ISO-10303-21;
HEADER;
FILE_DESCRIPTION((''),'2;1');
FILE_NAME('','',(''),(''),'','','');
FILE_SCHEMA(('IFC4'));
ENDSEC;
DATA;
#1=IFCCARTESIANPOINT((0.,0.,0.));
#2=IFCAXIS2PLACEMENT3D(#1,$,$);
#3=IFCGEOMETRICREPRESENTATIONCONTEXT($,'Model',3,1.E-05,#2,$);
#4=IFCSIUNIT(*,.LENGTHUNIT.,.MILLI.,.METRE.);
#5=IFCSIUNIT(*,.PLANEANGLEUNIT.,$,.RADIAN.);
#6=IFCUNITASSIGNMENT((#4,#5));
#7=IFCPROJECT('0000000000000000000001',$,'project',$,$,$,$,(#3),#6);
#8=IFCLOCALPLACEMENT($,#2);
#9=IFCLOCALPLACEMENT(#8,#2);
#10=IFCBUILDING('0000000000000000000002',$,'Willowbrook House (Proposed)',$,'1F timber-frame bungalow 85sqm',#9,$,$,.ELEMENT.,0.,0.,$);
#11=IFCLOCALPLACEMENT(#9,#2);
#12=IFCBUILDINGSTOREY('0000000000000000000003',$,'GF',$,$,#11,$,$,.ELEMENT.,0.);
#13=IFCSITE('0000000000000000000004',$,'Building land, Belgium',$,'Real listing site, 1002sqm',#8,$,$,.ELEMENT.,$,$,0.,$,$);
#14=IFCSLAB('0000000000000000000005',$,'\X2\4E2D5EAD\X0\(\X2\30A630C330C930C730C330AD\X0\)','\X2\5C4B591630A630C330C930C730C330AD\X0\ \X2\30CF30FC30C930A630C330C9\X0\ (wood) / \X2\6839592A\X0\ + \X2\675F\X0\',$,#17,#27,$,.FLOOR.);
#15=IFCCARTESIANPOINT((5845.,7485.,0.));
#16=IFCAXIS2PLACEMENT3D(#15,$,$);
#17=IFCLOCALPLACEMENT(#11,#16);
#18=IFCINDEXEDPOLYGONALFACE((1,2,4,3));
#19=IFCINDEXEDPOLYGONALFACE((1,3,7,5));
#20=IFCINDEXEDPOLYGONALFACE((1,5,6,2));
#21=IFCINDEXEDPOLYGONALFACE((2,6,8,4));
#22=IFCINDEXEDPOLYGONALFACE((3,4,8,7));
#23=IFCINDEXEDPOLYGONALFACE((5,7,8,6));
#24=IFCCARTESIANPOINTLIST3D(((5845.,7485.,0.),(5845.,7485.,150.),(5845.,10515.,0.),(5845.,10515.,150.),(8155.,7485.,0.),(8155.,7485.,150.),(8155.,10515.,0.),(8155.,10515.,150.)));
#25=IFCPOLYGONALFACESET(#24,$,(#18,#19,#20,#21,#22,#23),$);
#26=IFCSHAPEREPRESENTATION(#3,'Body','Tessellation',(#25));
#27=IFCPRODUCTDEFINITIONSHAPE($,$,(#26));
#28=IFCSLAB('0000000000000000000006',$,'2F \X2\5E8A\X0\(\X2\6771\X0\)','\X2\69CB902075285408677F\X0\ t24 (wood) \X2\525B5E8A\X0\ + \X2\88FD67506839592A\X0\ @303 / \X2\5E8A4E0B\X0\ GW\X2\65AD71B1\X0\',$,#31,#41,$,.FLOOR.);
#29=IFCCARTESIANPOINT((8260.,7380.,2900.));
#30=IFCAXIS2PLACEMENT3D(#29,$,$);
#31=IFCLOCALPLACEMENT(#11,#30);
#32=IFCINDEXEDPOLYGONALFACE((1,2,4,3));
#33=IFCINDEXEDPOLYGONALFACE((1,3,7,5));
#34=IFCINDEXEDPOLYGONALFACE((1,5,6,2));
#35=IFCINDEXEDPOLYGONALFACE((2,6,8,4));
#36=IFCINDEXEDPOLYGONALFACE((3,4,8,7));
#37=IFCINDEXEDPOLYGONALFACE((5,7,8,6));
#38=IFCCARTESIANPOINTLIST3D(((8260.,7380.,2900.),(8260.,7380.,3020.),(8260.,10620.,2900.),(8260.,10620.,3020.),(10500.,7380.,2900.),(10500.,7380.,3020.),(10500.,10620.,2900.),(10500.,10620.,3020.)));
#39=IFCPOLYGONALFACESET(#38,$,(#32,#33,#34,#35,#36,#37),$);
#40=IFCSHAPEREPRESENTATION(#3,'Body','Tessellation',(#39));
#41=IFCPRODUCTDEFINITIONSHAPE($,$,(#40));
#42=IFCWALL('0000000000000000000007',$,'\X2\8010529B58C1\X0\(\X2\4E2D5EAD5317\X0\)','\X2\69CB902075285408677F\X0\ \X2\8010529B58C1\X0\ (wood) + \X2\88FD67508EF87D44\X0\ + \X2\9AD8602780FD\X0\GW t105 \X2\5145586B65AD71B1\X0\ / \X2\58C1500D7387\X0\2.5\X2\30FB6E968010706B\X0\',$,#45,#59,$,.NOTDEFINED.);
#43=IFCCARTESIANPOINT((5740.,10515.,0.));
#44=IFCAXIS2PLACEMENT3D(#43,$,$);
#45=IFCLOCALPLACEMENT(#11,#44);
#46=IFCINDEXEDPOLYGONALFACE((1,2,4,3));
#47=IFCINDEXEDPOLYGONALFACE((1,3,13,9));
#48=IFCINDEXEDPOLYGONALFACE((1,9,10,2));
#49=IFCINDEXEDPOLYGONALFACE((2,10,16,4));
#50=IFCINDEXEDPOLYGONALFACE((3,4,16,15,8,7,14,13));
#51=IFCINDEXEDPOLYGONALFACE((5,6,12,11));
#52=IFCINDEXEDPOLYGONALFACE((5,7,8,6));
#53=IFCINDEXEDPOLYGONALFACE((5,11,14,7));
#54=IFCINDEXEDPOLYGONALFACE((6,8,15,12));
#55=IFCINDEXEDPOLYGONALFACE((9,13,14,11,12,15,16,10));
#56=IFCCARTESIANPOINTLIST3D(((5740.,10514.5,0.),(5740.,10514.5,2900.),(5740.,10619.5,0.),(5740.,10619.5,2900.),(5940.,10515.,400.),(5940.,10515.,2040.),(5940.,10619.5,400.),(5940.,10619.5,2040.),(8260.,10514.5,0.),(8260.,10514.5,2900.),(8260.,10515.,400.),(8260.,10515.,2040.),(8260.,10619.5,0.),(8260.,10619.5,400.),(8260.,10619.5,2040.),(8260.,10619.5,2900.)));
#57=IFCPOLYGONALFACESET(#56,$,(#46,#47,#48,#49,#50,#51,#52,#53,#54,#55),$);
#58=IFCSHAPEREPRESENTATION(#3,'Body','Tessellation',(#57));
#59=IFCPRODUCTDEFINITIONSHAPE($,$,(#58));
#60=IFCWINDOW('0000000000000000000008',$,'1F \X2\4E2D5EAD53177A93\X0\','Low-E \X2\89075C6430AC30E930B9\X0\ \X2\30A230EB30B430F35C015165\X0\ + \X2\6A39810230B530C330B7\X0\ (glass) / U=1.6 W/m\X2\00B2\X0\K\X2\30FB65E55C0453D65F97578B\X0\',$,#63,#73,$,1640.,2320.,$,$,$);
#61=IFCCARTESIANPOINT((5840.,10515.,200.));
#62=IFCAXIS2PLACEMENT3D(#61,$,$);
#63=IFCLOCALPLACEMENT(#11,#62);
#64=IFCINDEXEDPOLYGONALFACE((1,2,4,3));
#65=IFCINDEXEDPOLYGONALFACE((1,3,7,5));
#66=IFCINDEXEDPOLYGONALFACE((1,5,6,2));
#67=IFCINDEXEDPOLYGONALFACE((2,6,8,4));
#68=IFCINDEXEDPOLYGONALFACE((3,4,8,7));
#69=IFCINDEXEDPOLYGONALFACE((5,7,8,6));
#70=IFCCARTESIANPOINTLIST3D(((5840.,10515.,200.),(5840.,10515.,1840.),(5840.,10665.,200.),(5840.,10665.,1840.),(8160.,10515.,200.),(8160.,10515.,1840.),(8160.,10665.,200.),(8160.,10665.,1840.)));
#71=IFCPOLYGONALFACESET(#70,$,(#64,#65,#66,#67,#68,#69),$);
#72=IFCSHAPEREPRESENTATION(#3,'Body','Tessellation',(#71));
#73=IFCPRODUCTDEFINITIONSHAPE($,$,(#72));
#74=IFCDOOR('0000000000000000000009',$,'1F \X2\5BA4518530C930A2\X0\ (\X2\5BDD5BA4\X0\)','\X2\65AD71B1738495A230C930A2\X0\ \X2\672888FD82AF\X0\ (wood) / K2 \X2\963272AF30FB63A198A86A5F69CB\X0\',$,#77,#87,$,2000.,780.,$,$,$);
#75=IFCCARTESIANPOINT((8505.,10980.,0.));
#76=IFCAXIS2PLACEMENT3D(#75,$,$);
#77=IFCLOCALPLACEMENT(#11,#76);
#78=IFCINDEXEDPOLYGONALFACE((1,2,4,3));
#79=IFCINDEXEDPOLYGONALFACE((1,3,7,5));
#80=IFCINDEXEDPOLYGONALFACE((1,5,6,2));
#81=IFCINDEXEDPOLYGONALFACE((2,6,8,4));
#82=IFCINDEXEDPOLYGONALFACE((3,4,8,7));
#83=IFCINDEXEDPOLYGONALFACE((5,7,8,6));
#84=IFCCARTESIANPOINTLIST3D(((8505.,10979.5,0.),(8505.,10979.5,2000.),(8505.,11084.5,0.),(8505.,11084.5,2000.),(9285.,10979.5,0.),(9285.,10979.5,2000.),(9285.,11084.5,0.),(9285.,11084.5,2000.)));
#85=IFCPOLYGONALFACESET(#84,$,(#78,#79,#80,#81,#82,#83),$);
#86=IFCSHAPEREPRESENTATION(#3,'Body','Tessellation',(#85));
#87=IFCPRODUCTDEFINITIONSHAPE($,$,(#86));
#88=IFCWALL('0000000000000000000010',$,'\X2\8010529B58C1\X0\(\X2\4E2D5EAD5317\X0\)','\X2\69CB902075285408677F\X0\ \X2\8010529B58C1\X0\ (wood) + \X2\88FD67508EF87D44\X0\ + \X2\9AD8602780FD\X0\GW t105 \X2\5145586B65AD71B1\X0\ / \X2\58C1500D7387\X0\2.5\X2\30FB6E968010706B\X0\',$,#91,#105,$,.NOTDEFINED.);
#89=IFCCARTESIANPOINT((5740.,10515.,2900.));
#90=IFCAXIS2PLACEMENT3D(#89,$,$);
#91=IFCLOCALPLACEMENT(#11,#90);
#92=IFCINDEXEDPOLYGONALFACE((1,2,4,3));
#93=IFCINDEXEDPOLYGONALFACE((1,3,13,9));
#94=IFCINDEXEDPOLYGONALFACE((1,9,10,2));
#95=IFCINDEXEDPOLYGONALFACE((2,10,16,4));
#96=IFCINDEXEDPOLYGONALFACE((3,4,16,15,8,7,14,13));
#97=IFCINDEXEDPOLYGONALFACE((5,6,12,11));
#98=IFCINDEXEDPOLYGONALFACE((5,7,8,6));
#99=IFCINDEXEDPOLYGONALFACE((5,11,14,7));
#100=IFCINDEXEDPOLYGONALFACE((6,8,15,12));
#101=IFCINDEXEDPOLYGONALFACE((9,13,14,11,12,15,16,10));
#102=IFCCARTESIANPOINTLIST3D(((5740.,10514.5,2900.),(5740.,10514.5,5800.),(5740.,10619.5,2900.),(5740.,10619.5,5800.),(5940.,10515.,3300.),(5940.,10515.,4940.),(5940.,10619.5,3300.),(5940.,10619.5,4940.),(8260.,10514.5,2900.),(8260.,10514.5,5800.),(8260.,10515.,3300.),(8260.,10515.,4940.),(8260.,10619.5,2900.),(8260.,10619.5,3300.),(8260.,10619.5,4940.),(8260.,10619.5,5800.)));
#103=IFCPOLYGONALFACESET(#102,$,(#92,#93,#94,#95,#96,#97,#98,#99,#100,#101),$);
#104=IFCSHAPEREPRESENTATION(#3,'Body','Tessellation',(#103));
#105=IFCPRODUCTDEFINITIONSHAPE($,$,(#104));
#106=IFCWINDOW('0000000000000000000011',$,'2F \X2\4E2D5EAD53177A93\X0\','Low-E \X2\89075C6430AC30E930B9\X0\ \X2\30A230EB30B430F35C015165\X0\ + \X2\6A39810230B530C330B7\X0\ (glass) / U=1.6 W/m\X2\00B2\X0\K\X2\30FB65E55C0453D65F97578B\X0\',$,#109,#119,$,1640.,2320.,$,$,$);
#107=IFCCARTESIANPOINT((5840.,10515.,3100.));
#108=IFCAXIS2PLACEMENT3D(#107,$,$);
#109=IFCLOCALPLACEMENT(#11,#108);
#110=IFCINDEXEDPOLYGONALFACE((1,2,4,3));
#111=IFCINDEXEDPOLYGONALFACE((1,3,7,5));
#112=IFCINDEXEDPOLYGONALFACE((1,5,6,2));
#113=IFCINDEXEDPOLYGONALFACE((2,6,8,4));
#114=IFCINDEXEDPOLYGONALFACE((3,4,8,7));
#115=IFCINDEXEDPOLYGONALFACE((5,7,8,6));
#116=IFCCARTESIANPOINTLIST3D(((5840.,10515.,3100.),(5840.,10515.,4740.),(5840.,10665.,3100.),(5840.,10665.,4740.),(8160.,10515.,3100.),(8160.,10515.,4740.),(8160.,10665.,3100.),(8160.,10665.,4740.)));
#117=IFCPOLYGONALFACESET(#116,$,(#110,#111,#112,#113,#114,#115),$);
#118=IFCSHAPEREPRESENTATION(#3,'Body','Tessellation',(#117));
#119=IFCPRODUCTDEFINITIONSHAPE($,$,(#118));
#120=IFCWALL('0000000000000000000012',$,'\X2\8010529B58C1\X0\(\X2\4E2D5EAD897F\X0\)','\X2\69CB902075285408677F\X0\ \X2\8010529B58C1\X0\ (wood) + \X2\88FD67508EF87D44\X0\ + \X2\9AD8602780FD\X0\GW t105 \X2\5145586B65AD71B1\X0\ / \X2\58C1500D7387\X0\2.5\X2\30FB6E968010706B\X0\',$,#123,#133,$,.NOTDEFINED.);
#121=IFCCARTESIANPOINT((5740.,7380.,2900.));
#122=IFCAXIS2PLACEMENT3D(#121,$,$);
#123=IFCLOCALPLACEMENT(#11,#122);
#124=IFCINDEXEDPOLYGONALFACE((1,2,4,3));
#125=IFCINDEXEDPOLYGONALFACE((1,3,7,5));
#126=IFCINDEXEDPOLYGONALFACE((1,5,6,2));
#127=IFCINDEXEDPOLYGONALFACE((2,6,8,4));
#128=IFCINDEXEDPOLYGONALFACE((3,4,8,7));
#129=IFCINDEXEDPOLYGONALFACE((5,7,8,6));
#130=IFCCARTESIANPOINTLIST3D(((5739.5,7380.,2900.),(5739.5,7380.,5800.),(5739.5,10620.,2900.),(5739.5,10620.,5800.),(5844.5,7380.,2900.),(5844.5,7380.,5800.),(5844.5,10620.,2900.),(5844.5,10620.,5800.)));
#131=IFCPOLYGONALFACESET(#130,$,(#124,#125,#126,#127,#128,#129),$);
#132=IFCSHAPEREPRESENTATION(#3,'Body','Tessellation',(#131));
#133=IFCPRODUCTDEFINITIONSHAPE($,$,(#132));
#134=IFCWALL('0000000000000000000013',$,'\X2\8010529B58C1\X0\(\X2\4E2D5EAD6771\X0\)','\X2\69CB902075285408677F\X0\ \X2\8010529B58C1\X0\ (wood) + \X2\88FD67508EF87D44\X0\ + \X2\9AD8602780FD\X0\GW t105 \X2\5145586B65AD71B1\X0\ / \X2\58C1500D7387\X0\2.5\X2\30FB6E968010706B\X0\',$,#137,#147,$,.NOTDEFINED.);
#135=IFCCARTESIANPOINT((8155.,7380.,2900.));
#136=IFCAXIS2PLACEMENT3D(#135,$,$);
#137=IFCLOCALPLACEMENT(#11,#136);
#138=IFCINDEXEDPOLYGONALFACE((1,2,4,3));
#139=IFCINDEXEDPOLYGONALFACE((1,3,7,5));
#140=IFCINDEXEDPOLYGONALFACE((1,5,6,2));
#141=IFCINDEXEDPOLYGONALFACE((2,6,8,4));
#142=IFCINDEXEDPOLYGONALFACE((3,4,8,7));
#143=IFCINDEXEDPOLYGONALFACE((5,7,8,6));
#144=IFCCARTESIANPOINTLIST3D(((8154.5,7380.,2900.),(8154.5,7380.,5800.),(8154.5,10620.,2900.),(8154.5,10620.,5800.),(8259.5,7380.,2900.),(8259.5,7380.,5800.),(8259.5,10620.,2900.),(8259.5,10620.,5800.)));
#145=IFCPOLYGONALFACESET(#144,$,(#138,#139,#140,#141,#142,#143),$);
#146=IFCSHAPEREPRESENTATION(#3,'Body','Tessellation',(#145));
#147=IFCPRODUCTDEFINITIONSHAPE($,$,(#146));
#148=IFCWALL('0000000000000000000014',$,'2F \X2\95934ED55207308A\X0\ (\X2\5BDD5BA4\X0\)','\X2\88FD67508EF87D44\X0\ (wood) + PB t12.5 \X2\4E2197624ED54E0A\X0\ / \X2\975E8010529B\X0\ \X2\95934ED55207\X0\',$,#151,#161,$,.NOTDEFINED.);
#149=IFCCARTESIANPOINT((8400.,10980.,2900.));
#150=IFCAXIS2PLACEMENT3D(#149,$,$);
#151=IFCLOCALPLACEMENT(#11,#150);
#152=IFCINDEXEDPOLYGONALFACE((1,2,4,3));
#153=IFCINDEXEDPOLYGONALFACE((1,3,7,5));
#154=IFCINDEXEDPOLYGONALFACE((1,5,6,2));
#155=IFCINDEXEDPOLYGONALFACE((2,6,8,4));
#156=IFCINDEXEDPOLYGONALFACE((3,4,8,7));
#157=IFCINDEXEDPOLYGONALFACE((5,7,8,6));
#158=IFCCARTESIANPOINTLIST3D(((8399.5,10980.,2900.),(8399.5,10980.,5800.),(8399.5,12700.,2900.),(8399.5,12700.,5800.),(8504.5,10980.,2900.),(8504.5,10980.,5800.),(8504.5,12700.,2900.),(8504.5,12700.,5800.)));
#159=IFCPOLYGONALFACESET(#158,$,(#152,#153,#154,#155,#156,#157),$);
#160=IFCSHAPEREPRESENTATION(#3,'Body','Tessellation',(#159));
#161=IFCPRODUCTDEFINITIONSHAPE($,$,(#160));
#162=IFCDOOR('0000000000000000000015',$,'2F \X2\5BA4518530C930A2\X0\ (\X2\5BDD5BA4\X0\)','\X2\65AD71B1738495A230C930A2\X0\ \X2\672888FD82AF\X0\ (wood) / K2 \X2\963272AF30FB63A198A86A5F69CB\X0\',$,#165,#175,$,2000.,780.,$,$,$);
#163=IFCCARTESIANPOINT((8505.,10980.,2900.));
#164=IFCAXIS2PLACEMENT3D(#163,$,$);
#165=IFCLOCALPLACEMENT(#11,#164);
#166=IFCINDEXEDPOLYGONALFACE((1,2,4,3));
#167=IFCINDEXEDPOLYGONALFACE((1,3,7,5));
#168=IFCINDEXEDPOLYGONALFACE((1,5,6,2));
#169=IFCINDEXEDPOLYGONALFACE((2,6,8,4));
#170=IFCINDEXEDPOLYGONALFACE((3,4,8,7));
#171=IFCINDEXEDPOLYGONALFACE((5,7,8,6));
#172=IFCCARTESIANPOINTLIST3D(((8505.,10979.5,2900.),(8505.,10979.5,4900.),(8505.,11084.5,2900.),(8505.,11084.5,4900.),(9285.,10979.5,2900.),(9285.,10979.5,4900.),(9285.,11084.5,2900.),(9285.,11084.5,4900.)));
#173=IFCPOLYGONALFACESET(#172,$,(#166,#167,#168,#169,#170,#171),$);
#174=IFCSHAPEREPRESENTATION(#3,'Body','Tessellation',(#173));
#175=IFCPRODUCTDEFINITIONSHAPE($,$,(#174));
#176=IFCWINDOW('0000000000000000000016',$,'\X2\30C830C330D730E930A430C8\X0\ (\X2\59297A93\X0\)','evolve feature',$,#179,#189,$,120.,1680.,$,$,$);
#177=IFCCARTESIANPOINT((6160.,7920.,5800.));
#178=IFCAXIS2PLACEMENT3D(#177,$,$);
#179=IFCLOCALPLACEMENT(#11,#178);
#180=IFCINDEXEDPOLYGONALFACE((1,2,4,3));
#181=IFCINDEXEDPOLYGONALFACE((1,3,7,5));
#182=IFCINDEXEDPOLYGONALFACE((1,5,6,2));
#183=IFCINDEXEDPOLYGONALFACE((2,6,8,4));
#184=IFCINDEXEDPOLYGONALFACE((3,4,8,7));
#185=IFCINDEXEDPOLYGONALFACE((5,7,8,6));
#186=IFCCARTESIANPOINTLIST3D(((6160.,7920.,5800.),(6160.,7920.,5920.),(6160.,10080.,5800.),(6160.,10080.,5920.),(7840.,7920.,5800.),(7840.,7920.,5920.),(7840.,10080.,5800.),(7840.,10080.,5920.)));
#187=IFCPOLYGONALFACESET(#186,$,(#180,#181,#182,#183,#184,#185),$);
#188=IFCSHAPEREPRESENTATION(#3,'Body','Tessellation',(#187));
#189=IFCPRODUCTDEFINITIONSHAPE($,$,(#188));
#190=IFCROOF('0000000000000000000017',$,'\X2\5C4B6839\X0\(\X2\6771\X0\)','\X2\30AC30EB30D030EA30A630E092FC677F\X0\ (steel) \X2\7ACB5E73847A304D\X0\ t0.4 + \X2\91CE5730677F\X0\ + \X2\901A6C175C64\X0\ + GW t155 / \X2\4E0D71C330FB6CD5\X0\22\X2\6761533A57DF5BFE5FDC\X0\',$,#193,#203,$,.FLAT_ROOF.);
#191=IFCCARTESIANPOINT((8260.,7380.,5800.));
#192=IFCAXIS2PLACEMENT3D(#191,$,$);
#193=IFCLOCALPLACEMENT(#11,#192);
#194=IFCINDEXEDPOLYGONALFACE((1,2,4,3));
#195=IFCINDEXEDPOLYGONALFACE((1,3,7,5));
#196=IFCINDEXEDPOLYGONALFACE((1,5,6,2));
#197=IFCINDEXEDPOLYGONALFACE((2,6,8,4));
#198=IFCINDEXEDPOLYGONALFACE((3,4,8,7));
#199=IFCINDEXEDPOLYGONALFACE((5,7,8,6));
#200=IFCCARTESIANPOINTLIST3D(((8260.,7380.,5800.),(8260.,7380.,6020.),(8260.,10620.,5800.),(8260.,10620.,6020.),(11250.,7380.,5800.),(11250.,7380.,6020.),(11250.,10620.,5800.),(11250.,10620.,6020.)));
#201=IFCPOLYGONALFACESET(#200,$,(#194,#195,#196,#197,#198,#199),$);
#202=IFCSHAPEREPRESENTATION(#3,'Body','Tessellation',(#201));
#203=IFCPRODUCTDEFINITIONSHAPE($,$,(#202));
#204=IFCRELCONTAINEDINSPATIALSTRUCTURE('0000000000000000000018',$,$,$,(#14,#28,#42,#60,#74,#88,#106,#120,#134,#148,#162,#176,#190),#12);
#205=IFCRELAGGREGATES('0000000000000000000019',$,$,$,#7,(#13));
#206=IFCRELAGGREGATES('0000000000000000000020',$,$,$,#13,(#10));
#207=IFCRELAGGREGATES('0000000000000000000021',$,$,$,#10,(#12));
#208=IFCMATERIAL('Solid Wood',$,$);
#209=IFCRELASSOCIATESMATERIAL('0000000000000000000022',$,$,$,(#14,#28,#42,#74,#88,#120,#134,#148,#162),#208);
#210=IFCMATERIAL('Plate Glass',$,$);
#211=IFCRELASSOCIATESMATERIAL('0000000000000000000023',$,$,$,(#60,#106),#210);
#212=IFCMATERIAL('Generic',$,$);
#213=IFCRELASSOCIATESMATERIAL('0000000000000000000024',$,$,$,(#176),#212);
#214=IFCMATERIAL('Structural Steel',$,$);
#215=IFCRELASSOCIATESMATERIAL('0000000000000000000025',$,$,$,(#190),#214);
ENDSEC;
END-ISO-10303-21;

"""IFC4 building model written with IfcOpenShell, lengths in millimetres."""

from ifc_helpers import new_model, si_unit, frame, frame_2d, origin, place, context, project, spatial, rectangle, extrude, material, element, fill, save


model = new_model("IFC4")

# Units and contexts
model_context = context("Model", 3, precision=1e-05, world=origin())
ifc_project = project(units=[si_unit("LENGTHUNIT", "METRE", prefix="MILLI"), si_unit("PLANEANGLEUNIT", "RADIAN")], contexts=[model_context])

# Site, building, storey
site_placement = place(None, origin())
site = spatial("IfcSite", under=ifc_project, at=site_placement, Name="Building land, Belgium", ObjectType="Real listing site, 1002sqm", CompositionType="ELEMENT", RefElevation=0.0)
building_placement = place(site_placement, origin())
building = spatial("IfcBuilding", under=site, at=building_placement, Name="Willowbrook House (Proposed)", ObjectType="1F timber-frame bungalow 85sqm", CompositionType="ELEMENT", ElevationOfRefHeight=0.0, ElevationOfTerrain=0.0)
storey_placement = place(building_placement, origin())
storey = spatial("IfcBuildingStorey", under=building, at=storey_placement, Name="GF", CompositionType="ELEMENT", Elevation=0.0)

# Slabs
ifc_material_1 = material(Name="Solid Wood")
slab_1_placement = place(storey_placement, frame((5845.0, 7485.0, 0.0)))
element("IfcSlab", 1, at=slab_1_placement, inside=storey, material=ifc_material_1, Name="中庭(ウッドデッキ)", Description="屋外ウッドデッキ ハードウッド (wood) / 根太 + 束", PredefinedType="FLOOR", context=model_context, shape_type="SweptSolid", body=[
    extrude(rectangle(XDim=2310.0, YDim=3030.0, at=frame_2d((1155.0, 1515.0))), frame((5845.0, 7485.0, 0.0)), (0.0, 0.0, 1.0), 150.0),
])
slab_2_placement = place(storey_placement, frame((8260.0, 7380.0, 2900.0)))
element("IfcSlab", 2, at=slab_2_placement, inside=storey, material=ifc_material_1, Name="2F 床(東)", Description="構造用合板 t24 (wood) 剛床 + 製材根太 @303 / 床下 GW断熱", PredefinedType="FLOOR", context=model_context, shape_type="SweptSolid", body=[
    extrude(rectangle(XDim=2240.0, YDim=3240.0, at=frame_2d((1120.0, 1620.0))), frame((8260.0, 7380.0, 2900.0)), (0.0, 0.0, 1.0), 120.0),
])

# Wall, opening, window
wall_1_placement = place(storey_placement, frame((5740.0, 10515.0, 0.0)))
wall_1 = element("IfcWall", 3, at=wall_1_placement, inside=storey, material=ifc_material_1, Name="耐力壁(中庭北)", Description="構造用合板 耐力壁 (wood) + 製材軸組 + 高性能GW t105 充填断熱 / 壁倍率2.5・準耐火", PredefinedType="NOTDEFINED", context=model_context, shape_type="SweptSolid", body=[
    extrude(rectangle(XDim=2520.0, YDim=105.0, at=frame_2d((1260.0, 52.0))), frame((5740.0, 10515.0, 0.0)), (0.0, 0.0, 1.0), 2900.0),
])
opening_1_placement = place(storey_placement, frame((5840.0, 10515.0, 200.0)))
opening_1 = element("IfcOpeningElement", 4, at=opening_1_placement, cuts=wall_1, PredefinedType="NOTDEFINED", context=model_context, shape_type="SweptSolid", body=[
    extrude(rectangle(XDim=2320.0, YDim=150.0, at=frame_2d((1160.0, 75.0))), frame((5840.0, 10515.0, 200.0)), (0.0, 0.0, 1.0), 1640.0),
])
ifc_material_2 = material(Name="Plate Glass")
window_1_placement = place(storey_placement, frame((5840.0, 10515.0, 200.0)))
window_1 = element("IfcWindow", 5, at=window_1_placement, inside=storey, material=ifc_material_2, Name="1F 中庭北窓", Description="Low-E 複層ガラス アルゴン封入 + 樹脂サッシ (glass) / U=1.6 W/m²K・日射取得型", OverallHeight=1640.0, OverallWidth=2320.0, context=model_context, shape_type="SweptSolid", body=[
    extrude(rectangle(XDim=2320.0, YDim=150.0, at=frame_2d((1160.0, 75.0))), frame((5840.0, 10515.0, 200.0)), (0.0, 0.0, 1.0), 1640.0),
])
fill(opening_1, window_1)

# Door
door_1_placement = place(storey_placement, frame((8505.0, 10980.0, 0.0)))
element("IfcDoor", 6, at=door_1_placement, inside=storey, material=ifc_material_1, Name="1F 室内ドア (寝室)", Description="断熱玄関ドア 木製芯 (wood) / K2 防犯・採風機構", OverallHeight=2000.0, OverallWidth=780.0, context=model_context, shape_type="SweptSolid", body=[
    extrude(rectangle(XDim=780.0, YDim=105.0, at=frame_2d((390.0, 52.0))), frame((8505.0, 10980.0, 0.0)), (0.0, 0.0, 1.0), 2000.0),
])

# Wall, opening, window
wall_2_placement = place(storey_placement, frame((5740.0, 10515.0, 2900.0)))
wall_2 = element("IfcWall", 7, at=wall_2_placement, inside=storey, material=ifc_material_1, Name="耐力壁(中庭北)", Description="構造用合板 耐力壁 (wood) + 製材軸組 + 高性能GW t105 充填断熱 / 壁倍率2.5・準耐火", PredefinedType="NOTDEFINED", context=model_context, shape_type="SweptSolid", body=[
    extrude(rectangle(XDim=2520.0, YDim=105.0, at=frame_2d((1260.0, 52.0))), frame((5740.0, 10515.0, 2900.0)), (0.0, 0.0, 1.0), 2900.0),
])
opening_2_placement = place(storey_placement, frame((5840.0, 10515.0, 3100.0)))
opening_2 = element("IfcOpeningElement", 8, at=opening_2_placement, cuts=wall_2, PredefinedType="NOTDEFINED", context=model_context, shape_type="SweptSolid", body=[
    extrude(rectangle(XDim=2320.0, YDim=150.0, at=frame_2d((1160.0, 75.0))), frame((5840.0, 10515.0, 3100.0)), (0.0, 0.0, 1.0), 1640.0),
])
window_2_placement = place(storey_placement, frame((5840.0, 10515.0, 3100.0)))
window_2 = element("IfcWindow", 9, at=window_2_placement, inside=storey, material=ifc_material_2, Name="2F 中庭北窓", Description="Low-E 複層ガラス アルゴン封入 + 樹脂サッシ (glass) / U=1.6 W/m²K・日射取得型", OverallHeight=1640.0, OverallWidth=2320.0, context=model_context, shape_type="SweptSolid", body=[
    extrude(rectangle(XDim=2320.0, YDim=150.0, at=frame_2d((1160.0, 75.0))), frame((5840.0, 10515.0, 3100.0)), (0.0, 0.0, 1.0), 1640.0),
])
fill(opening_2, window_2)

# Walls
wall_3_placement = place(storey_placement, frame((5740.0, 7380.0, 2900.0)))
element("IfcWall", 10, at=wall_3_placement, inside=storey, material=ifc_material_1, Name="耐力壁(中庭西)", Description="構造用合板 耐力壁 (wood) + 製材軸組 + 高性能GW t105 充填断熱 / 壁倍率2.5・準耐火", PredefinedType="NOTDEFINED", context=model_context, shape_type="SweptSolid", body=[
    extrude(rectangle(XDim=105.0, YDim=3240.0, at=frame_2d((52.0, 1620.0))), frame((5740.0, 7380.0, 2900.0)), (0.0, 0.0, 1.0), 2900.0),
])
wall_4_placement = place(storey_placement, frame((8155.0, 7380.0, 2900.0)))
element("IfcWall", 11, at=wall_4_placement, inside=storey, material=ifc_material_1, Name="耐力壁(中庭東)", Description="構造用合板 耐力壁 (wood) + 製材軸組 + 高性能GW t105 充填断熱 / 壁倍率2.5・準耐火", PredefinedType="NOTDEFINED", context=model_context, shape_type="SweptSolid", body=[
    extrude(rectangle(XDim=105.0, YDim=3240.0, at=frame_2d((52.0, 1620.0))), frame((8155.0, 7380.0, 2900.0)), (0.0, 0.0, 1.0), 2900.0),
])
wall_5_placement = place(storey_placement, frame((8400.0, 10980.0, 2900.0)))
element("IfcWall", 12, at=wall_5_placement, inside=storey, material=ifc_material_1, Name="2F 間仕切り (寝室)", Description="製材軸組 (wood) + PB t12.5 両面仕上 / 非耐力 間仕切", PredefinedType="NOTDEFINED", context=model_context, shape_type="SweptSolid", body=[
    extrude(rectangle(XDim=105.0, YDim=1720.0, at=frame_2d((52.0, 860.0))), frame((8400.0, 10980.0, 2900.0)), (0.0, 0.0, 1.0), 2900.0),
])

# Door
door_2_placement = place(storey_placement, frame((8505.0, 10980.0, 2900.0)))
element("IfcDoor", 13, at=door_2_placement, inside=storey, material=ifc_material_1, Name="2F 室内ドア (寝室)", Description="断熱玄関ドア 木製芯 (wood) / K2 防犯・採風機構", OverallHeight=2000.0, OverallWidth=780.0, context=model_context, shape_type="SweptSolid", body=[
    extrude(rectangle(XDim=780.0, YDim=105.0, at=frame_2d((390.0, 52.0))), frame((8505.0, 10980.0, 2900.0)), (0.0, 0.0, 1.0), 2000.0),
])

# Window
ifc_material_3 = material(Name="Generic")
window_3_placement = place(storey_placement, frame((6160.0, 7920.0, 5800.0)))
element("IfcWindow", 14, at=window_3_placement, inside=storey, material=ifc_material_3, Name="トップライト (天窓)", Description="evolve feature", OverallHeight=120.0, OverallWidth=1680.0, context=model_context, shape_type="SweptSolid", body=[
    extrude(rectangle(XDim=1680.0, YDim=2160.0, at=frame_2d((840.0, 1080.0))), frame((6160.0, 7920.0, 5800.0)), (0.0, 0.0, 1.0), 120.0),
])

# Roof
ifc_material_4 = material(Name="Structural Steel")
roof_placement = place(storey_placement, frame((8260.0, 7380.0, 5800.0)))
element("IfcRoof", 15, at=roof_placement, inside=storey, material=ifc_material_4, Name="屋根(東)", Description="ガルバリウム鋼板 (steel) 立平葺き t0.4 + 野地板 + 通気層 + GW t155 / 不燃・法22条区域対応", PredefinedType="FLAT_ROOF", context=model_context, shape_type="SweptSolid", body=[
    extrude(rectangle(XDim=2990.0, YDim=3240.0, at=frame_2d((1495.0, 1620.0))), frame((8260.0, 7380.0, 5800.0)), (0.0, 0.0, 1.0), 220.0),
])

save(model, "model.ifc")
